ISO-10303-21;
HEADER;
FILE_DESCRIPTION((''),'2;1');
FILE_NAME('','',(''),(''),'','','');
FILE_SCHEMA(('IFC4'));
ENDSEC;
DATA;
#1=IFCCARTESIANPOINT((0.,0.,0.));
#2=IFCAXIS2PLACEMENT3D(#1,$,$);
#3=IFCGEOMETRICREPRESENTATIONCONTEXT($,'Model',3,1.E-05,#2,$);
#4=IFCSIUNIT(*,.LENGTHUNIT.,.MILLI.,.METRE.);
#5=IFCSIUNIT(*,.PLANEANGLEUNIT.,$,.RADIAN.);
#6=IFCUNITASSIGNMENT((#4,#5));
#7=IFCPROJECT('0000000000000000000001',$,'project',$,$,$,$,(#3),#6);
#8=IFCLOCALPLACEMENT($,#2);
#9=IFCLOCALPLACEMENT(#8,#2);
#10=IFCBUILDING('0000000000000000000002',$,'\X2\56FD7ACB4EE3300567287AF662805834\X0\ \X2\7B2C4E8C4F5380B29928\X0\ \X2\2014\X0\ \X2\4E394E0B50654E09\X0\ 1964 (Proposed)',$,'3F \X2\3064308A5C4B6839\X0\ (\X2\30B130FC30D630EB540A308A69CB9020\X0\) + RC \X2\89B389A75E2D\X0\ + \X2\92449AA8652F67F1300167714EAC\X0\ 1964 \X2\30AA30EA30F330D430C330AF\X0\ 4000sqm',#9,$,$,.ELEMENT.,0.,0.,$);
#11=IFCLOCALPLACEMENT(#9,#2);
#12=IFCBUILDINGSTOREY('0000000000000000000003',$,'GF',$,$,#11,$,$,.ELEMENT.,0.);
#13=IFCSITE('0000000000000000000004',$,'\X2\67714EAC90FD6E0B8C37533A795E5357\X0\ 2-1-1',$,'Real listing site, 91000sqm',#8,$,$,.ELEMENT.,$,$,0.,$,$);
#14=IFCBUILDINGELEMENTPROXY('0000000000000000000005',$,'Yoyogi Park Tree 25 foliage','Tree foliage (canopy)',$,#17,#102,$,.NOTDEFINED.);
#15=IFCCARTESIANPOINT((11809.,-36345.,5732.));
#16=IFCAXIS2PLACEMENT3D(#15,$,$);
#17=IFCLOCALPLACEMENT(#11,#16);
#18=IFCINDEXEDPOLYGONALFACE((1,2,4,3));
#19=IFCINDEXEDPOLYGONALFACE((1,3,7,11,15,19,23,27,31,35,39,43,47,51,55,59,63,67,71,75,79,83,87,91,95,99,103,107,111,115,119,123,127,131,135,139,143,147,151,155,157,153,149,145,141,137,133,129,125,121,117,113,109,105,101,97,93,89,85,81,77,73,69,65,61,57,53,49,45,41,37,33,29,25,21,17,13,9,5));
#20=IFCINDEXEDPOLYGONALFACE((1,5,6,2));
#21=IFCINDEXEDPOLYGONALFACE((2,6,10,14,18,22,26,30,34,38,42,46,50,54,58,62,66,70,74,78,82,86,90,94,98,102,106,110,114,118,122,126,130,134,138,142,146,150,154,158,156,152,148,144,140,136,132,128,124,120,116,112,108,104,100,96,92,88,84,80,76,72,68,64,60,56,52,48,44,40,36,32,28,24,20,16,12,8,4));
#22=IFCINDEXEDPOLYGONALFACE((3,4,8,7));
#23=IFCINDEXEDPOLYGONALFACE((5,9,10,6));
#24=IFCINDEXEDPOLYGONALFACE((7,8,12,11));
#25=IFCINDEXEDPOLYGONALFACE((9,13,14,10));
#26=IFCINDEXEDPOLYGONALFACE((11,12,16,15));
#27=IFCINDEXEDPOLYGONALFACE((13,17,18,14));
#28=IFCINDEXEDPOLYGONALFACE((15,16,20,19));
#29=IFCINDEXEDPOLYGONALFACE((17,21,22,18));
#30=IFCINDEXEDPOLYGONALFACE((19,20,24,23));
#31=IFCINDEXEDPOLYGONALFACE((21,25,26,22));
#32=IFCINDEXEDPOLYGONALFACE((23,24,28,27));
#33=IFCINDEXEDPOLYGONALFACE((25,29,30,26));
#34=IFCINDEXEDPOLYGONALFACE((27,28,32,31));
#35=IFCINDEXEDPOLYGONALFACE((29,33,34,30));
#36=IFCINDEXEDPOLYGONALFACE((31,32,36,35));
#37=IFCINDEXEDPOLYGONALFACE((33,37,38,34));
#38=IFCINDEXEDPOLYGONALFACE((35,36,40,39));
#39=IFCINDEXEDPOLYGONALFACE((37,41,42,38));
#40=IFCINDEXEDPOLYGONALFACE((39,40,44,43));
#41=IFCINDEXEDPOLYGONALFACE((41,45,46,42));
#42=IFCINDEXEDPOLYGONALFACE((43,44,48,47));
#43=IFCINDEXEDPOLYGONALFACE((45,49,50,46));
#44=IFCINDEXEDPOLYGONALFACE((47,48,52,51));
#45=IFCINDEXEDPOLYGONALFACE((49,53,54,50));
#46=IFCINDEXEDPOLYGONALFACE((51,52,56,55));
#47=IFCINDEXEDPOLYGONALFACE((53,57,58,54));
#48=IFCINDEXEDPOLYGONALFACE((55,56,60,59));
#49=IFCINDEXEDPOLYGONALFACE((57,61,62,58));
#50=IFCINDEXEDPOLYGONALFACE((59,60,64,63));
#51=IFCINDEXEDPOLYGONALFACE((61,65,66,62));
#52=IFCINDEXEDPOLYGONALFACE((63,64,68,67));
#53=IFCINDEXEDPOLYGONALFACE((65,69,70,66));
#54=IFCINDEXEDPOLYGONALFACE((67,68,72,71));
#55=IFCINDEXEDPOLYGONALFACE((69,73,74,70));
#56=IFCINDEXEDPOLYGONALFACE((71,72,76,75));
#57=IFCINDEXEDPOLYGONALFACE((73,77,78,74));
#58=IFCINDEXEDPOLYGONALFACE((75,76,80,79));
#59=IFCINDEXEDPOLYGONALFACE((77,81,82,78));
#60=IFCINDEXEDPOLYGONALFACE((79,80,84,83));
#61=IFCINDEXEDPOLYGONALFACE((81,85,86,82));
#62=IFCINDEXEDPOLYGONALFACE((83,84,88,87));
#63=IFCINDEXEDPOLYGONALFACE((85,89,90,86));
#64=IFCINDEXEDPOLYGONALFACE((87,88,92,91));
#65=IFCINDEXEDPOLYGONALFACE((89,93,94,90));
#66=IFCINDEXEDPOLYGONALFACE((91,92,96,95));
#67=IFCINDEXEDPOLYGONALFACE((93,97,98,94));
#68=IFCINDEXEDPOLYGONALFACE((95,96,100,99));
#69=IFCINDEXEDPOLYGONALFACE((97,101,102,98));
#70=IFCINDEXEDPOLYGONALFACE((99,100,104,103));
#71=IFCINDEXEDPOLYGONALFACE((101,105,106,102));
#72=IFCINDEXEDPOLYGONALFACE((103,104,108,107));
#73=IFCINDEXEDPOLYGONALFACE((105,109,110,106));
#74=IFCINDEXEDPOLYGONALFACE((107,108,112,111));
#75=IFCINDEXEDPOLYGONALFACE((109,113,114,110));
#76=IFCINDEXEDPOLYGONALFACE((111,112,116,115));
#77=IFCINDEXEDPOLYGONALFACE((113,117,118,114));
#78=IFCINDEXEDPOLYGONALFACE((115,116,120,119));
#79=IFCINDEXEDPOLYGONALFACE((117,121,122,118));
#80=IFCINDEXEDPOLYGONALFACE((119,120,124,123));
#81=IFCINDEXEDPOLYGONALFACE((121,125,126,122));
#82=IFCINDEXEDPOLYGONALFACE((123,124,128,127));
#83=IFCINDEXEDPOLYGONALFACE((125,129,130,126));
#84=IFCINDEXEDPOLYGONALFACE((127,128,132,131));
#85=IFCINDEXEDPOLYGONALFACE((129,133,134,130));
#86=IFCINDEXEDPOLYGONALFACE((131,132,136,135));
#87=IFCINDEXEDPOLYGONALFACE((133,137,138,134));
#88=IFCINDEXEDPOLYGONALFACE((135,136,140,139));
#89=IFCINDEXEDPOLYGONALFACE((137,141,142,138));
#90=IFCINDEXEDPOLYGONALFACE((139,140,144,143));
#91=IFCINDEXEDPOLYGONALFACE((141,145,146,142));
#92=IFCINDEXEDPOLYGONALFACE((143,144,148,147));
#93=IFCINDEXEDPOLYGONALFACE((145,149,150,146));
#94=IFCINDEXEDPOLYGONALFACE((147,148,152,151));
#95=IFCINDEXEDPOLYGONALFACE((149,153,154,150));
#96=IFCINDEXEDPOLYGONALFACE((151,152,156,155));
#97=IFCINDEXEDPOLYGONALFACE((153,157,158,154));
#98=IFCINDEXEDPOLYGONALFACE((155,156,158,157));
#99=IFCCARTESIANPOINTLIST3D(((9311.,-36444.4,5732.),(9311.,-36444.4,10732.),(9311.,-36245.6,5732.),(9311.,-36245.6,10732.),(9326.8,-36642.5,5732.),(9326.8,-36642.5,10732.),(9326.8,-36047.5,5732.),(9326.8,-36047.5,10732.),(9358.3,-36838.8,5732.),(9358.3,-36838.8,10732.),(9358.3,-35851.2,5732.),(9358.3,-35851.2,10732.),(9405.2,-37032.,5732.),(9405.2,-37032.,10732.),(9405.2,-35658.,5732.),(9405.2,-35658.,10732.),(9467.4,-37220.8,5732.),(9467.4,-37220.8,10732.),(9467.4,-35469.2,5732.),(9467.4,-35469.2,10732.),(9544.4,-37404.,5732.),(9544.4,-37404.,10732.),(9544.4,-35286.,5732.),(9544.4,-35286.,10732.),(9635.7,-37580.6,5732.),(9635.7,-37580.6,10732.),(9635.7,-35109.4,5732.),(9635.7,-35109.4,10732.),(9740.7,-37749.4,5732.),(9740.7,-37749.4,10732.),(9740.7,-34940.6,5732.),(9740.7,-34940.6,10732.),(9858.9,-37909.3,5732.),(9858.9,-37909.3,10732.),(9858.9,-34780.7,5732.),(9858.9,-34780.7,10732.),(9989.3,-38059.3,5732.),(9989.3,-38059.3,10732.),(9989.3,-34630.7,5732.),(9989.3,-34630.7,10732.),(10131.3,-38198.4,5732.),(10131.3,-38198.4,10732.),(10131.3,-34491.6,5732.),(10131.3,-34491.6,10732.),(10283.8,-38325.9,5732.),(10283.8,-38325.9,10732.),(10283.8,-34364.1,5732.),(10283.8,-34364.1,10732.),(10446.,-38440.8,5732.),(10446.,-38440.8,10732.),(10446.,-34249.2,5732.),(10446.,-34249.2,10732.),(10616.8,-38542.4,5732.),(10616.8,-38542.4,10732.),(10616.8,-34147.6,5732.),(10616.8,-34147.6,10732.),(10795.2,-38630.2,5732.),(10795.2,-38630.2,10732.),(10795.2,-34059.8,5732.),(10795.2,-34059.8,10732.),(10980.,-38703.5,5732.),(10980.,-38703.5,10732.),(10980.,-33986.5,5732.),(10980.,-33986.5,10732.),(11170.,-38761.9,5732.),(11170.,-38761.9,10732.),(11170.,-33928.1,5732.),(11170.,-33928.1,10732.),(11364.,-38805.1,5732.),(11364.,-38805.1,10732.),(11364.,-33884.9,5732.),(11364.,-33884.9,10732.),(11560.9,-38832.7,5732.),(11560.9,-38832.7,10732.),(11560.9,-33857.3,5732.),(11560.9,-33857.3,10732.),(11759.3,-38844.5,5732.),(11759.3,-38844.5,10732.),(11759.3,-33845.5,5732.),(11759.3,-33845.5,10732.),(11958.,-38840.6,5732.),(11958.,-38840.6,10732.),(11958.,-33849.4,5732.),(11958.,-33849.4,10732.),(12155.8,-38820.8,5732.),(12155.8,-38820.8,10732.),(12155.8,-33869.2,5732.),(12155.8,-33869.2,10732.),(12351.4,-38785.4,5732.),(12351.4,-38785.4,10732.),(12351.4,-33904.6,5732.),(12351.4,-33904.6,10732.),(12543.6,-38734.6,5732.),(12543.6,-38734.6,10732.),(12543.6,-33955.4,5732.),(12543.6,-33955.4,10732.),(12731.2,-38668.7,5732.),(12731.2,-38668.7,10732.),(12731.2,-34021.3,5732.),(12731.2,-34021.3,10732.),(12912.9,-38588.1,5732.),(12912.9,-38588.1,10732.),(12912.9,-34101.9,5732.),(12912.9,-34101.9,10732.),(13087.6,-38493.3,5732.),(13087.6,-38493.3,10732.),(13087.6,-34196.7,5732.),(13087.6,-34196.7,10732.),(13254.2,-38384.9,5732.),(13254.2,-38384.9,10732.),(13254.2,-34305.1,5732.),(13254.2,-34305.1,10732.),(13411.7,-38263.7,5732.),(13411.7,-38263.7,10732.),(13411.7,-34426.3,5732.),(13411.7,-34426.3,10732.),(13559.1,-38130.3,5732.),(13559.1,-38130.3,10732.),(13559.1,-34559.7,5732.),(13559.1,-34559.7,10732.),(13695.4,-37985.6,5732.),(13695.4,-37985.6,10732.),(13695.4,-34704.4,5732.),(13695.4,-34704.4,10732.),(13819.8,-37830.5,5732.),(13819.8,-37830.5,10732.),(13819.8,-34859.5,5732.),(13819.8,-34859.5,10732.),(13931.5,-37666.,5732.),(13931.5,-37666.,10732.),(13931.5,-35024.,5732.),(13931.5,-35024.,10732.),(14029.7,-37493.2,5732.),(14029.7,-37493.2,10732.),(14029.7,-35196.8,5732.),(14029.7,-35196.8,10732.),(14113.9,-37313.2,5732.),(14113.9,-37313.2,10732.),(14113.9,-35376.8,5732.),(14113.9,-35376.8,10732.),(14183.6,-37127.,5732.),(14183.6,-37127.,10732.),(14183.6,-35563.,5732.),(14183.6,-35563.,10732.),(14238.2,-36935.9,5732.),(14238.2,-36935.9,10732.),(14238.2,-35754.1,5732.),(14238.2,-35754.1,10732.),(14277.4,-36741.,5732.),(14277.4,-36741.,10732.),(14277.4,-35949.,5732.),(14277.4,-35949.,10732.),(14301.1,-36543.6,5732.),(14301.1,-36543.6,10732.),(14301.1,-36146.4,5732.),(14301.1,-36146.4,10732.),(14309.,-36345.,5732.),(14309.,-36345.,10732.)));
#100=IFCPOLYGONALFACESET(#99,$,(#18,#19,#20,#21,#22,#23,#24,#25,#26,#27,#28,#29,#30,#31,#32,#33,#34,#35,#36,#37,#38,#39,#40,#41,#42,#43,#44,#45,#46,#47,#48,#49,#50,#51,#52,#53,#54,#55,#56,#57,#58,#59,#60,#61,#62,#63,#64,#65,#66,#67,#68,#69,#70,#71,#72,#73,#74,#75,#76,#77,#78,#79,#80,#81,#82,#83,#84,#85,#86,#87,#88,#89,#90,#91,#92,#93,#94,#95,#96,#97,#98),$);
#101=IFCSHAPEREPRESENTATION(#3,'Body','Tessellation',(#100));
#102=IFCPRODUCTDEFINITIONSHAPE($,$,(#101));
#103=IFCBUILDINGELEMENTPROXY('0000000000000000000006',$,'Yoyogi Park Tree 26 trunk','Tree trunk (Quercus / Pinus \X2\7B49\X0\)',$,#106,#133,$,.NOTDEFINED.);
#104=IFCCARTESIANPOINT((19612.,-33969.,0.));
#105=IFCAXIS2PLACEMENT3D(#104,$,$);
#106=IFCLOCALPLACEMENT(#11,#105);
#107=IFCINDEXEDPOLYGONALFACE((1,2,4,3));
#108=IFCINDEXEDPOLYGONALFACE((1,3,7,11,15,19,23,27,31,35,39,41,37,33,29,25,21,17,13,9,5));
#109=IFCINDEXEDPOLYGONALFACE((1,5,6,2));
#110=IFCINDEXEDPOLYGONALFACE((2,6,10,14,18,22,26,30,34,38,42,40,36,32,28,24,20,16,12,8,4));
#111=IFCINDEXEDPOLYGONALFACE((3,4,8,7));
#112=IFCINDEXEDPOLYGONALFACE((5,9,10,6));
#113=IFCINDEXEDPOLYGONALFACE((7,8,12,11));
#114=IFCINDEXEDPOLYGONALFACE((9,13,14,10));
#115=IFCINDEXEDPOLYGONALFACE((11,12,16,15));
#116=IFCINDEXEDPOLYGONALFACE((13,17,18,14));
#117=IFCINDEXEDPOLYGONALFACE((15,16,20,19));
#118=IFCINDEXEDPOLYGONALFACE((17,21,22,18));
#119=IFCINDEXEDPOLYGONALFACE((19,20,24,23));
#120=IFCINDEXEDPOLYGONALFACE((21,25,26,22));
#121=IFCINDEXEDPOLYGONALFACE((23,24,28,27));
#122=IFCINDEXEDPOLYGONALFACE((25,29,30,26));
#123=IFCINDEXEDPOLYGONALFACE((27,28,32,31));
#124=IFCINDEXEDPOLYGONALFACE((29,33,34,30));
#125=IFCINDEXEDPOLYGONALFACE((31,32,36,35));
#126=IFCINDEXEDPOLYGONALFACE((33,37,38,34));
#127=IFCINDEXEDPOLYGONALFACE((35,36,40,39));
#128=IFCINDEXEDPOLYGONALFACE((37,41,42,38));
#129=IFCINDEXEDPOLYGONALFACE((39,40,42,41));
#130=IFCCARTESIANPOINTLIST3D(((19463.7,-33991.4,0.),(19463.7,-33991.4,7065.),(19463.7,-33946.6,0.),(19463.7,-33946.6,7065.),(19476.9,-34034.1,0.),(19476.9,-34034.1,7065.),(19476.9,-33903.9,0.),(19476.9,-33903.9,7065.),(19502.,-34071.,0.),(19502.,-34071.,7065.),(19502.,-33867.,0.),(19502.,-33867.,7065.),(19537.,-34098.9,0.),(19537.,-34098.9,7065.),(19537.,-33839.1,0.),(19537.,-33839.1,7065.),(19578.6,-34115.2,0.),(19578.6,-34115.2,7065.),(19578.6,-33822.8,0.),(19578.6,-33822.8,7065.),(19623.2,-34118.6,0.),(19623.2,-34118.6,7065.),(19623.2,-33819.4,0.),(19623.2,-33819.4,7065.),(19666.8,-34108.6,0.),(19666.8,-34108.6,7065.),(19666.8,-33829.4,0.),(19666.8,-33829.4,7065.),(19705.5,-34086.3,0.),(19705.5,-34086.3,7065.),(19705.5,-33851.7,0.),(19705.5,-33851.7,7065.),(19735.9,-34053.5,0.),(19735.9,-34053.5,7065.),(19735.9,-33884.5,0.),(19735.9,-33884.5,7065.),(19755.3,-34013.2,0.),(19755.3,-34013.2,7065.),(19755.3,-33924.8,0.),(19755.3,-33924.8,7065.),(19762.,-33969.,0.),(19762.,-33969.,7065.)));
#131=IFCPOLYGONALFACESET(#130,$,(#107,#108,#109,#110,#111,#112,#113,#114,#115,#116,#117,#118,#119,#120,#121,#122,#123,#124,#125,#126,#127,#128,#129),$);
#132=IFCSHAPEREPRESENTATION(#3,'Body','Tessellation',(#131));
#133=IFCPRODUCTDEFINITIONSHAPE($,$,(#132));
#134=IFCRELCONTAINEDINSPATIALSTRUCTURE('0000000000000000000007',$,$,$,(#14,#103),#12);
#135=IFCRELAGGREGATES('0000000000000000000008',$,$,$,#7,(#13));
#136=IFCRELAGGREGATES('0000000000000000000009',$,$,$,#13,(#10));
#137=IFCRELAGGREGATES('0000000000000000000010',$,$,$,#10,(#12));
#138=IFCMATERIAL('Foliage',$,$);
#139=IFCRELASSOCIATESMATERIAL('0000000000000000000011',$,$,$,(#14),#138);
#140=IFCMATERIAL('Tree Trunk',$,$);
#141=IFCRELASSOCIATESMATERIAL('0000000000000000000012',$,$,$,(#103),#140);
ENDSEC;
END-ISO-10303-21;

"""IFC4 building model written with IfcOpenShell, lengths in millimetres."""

from ifc_helpers import new_model, si_unit, frame, origin, origin_2d, place, context, project, spatial, circle, extrude, material, element, save


model = new_model("IFC4")

# Units and contexts
model_context = context("Model", 3, precision=1e-05, world=origin())
ifc_project = project(units=[si_unit("LENGTHUNIT", "METRE", prefix="MILLI"), si_unit("PLANEANGLEUNIT", "RADIAN")], contexts=[model_context])

# Site, building, storey
site_placement = place(None, origin())
site = spatial("IfcSite", under=ifc_project, at=site_placement, Name="東京都渋谷区神南 2-1-1", ObjectType="Real listing site, 91000sqm", CompositionType="ELEMENT", RefElevation=0.0)
building_placement = place(site_placement, origin())
building = spatial("IfcBuilding", under=site, at=building_placement, Name="国立代々木競技場 第二体育館 — 丹下健三 1964 (Proposed)", ObjectType="3F つり屋根 (ケーブル吊り構造) + RC 観覧席 + 鉄骨支柱、東京 1964 オリンピック 4000sqm", CompositionType="ELEMENT", ElevationOfRefHeight=0.0, ElevationOfTerrain=0.0)
storey_placement = place(building_placement, origin())
storey = spatial("IfcBuildingStorey", under=building, at=storey_placement, Name="GF", CompositionType="ELEMENT", Elevation=0.0)

# Building element proxies
ifc_material_1 = material(Name="Tree Trunk")
ifc_material_2 = material(Name="Foliage")
proxy_1_placement = place(storey_placement, frame((11809.0, -36345.0, 5732.0)))
element("IfcBuildingElementProxy", 1, at=proxy_1_placement, inside=storey, material=ifc_material_2, Name="Yoyogi Park Tree 25 foliage", Description="Tree foliage (canopy)", PredefinedType="NOTDEFINED", context=model_context, shape_type="SweptSolid", body=[
    extrude(circle(Radius=2500.0, at=origin_2d()), frame((11809.0, -36345.0, 5732.0)), (0.0, 0.0, 1.0), 5000.0),
])
proxy_2_placement = place(storey_placement, frame((19612.0, -33969.0, 0.0)))
element("IfcBuildingElementProxy", 2, at=proxy_2_placement, inside=storey, material=ifc_material_1, Name="Yoyogi Park Tree 26 trunk", Description="Tree trunk (Quercus / Pinus 等)", PredefinedType="NOTDEFINED", context=model_context, shape_type="SweptSolid", body=[
    extrude(circle(Radius=150.0, at=origin_2d()), frame((19612.0, -33969.0, 0.0)), (0.0, 0.0, 1.0), 7065.0),
])

save(model, "model.ifc")
